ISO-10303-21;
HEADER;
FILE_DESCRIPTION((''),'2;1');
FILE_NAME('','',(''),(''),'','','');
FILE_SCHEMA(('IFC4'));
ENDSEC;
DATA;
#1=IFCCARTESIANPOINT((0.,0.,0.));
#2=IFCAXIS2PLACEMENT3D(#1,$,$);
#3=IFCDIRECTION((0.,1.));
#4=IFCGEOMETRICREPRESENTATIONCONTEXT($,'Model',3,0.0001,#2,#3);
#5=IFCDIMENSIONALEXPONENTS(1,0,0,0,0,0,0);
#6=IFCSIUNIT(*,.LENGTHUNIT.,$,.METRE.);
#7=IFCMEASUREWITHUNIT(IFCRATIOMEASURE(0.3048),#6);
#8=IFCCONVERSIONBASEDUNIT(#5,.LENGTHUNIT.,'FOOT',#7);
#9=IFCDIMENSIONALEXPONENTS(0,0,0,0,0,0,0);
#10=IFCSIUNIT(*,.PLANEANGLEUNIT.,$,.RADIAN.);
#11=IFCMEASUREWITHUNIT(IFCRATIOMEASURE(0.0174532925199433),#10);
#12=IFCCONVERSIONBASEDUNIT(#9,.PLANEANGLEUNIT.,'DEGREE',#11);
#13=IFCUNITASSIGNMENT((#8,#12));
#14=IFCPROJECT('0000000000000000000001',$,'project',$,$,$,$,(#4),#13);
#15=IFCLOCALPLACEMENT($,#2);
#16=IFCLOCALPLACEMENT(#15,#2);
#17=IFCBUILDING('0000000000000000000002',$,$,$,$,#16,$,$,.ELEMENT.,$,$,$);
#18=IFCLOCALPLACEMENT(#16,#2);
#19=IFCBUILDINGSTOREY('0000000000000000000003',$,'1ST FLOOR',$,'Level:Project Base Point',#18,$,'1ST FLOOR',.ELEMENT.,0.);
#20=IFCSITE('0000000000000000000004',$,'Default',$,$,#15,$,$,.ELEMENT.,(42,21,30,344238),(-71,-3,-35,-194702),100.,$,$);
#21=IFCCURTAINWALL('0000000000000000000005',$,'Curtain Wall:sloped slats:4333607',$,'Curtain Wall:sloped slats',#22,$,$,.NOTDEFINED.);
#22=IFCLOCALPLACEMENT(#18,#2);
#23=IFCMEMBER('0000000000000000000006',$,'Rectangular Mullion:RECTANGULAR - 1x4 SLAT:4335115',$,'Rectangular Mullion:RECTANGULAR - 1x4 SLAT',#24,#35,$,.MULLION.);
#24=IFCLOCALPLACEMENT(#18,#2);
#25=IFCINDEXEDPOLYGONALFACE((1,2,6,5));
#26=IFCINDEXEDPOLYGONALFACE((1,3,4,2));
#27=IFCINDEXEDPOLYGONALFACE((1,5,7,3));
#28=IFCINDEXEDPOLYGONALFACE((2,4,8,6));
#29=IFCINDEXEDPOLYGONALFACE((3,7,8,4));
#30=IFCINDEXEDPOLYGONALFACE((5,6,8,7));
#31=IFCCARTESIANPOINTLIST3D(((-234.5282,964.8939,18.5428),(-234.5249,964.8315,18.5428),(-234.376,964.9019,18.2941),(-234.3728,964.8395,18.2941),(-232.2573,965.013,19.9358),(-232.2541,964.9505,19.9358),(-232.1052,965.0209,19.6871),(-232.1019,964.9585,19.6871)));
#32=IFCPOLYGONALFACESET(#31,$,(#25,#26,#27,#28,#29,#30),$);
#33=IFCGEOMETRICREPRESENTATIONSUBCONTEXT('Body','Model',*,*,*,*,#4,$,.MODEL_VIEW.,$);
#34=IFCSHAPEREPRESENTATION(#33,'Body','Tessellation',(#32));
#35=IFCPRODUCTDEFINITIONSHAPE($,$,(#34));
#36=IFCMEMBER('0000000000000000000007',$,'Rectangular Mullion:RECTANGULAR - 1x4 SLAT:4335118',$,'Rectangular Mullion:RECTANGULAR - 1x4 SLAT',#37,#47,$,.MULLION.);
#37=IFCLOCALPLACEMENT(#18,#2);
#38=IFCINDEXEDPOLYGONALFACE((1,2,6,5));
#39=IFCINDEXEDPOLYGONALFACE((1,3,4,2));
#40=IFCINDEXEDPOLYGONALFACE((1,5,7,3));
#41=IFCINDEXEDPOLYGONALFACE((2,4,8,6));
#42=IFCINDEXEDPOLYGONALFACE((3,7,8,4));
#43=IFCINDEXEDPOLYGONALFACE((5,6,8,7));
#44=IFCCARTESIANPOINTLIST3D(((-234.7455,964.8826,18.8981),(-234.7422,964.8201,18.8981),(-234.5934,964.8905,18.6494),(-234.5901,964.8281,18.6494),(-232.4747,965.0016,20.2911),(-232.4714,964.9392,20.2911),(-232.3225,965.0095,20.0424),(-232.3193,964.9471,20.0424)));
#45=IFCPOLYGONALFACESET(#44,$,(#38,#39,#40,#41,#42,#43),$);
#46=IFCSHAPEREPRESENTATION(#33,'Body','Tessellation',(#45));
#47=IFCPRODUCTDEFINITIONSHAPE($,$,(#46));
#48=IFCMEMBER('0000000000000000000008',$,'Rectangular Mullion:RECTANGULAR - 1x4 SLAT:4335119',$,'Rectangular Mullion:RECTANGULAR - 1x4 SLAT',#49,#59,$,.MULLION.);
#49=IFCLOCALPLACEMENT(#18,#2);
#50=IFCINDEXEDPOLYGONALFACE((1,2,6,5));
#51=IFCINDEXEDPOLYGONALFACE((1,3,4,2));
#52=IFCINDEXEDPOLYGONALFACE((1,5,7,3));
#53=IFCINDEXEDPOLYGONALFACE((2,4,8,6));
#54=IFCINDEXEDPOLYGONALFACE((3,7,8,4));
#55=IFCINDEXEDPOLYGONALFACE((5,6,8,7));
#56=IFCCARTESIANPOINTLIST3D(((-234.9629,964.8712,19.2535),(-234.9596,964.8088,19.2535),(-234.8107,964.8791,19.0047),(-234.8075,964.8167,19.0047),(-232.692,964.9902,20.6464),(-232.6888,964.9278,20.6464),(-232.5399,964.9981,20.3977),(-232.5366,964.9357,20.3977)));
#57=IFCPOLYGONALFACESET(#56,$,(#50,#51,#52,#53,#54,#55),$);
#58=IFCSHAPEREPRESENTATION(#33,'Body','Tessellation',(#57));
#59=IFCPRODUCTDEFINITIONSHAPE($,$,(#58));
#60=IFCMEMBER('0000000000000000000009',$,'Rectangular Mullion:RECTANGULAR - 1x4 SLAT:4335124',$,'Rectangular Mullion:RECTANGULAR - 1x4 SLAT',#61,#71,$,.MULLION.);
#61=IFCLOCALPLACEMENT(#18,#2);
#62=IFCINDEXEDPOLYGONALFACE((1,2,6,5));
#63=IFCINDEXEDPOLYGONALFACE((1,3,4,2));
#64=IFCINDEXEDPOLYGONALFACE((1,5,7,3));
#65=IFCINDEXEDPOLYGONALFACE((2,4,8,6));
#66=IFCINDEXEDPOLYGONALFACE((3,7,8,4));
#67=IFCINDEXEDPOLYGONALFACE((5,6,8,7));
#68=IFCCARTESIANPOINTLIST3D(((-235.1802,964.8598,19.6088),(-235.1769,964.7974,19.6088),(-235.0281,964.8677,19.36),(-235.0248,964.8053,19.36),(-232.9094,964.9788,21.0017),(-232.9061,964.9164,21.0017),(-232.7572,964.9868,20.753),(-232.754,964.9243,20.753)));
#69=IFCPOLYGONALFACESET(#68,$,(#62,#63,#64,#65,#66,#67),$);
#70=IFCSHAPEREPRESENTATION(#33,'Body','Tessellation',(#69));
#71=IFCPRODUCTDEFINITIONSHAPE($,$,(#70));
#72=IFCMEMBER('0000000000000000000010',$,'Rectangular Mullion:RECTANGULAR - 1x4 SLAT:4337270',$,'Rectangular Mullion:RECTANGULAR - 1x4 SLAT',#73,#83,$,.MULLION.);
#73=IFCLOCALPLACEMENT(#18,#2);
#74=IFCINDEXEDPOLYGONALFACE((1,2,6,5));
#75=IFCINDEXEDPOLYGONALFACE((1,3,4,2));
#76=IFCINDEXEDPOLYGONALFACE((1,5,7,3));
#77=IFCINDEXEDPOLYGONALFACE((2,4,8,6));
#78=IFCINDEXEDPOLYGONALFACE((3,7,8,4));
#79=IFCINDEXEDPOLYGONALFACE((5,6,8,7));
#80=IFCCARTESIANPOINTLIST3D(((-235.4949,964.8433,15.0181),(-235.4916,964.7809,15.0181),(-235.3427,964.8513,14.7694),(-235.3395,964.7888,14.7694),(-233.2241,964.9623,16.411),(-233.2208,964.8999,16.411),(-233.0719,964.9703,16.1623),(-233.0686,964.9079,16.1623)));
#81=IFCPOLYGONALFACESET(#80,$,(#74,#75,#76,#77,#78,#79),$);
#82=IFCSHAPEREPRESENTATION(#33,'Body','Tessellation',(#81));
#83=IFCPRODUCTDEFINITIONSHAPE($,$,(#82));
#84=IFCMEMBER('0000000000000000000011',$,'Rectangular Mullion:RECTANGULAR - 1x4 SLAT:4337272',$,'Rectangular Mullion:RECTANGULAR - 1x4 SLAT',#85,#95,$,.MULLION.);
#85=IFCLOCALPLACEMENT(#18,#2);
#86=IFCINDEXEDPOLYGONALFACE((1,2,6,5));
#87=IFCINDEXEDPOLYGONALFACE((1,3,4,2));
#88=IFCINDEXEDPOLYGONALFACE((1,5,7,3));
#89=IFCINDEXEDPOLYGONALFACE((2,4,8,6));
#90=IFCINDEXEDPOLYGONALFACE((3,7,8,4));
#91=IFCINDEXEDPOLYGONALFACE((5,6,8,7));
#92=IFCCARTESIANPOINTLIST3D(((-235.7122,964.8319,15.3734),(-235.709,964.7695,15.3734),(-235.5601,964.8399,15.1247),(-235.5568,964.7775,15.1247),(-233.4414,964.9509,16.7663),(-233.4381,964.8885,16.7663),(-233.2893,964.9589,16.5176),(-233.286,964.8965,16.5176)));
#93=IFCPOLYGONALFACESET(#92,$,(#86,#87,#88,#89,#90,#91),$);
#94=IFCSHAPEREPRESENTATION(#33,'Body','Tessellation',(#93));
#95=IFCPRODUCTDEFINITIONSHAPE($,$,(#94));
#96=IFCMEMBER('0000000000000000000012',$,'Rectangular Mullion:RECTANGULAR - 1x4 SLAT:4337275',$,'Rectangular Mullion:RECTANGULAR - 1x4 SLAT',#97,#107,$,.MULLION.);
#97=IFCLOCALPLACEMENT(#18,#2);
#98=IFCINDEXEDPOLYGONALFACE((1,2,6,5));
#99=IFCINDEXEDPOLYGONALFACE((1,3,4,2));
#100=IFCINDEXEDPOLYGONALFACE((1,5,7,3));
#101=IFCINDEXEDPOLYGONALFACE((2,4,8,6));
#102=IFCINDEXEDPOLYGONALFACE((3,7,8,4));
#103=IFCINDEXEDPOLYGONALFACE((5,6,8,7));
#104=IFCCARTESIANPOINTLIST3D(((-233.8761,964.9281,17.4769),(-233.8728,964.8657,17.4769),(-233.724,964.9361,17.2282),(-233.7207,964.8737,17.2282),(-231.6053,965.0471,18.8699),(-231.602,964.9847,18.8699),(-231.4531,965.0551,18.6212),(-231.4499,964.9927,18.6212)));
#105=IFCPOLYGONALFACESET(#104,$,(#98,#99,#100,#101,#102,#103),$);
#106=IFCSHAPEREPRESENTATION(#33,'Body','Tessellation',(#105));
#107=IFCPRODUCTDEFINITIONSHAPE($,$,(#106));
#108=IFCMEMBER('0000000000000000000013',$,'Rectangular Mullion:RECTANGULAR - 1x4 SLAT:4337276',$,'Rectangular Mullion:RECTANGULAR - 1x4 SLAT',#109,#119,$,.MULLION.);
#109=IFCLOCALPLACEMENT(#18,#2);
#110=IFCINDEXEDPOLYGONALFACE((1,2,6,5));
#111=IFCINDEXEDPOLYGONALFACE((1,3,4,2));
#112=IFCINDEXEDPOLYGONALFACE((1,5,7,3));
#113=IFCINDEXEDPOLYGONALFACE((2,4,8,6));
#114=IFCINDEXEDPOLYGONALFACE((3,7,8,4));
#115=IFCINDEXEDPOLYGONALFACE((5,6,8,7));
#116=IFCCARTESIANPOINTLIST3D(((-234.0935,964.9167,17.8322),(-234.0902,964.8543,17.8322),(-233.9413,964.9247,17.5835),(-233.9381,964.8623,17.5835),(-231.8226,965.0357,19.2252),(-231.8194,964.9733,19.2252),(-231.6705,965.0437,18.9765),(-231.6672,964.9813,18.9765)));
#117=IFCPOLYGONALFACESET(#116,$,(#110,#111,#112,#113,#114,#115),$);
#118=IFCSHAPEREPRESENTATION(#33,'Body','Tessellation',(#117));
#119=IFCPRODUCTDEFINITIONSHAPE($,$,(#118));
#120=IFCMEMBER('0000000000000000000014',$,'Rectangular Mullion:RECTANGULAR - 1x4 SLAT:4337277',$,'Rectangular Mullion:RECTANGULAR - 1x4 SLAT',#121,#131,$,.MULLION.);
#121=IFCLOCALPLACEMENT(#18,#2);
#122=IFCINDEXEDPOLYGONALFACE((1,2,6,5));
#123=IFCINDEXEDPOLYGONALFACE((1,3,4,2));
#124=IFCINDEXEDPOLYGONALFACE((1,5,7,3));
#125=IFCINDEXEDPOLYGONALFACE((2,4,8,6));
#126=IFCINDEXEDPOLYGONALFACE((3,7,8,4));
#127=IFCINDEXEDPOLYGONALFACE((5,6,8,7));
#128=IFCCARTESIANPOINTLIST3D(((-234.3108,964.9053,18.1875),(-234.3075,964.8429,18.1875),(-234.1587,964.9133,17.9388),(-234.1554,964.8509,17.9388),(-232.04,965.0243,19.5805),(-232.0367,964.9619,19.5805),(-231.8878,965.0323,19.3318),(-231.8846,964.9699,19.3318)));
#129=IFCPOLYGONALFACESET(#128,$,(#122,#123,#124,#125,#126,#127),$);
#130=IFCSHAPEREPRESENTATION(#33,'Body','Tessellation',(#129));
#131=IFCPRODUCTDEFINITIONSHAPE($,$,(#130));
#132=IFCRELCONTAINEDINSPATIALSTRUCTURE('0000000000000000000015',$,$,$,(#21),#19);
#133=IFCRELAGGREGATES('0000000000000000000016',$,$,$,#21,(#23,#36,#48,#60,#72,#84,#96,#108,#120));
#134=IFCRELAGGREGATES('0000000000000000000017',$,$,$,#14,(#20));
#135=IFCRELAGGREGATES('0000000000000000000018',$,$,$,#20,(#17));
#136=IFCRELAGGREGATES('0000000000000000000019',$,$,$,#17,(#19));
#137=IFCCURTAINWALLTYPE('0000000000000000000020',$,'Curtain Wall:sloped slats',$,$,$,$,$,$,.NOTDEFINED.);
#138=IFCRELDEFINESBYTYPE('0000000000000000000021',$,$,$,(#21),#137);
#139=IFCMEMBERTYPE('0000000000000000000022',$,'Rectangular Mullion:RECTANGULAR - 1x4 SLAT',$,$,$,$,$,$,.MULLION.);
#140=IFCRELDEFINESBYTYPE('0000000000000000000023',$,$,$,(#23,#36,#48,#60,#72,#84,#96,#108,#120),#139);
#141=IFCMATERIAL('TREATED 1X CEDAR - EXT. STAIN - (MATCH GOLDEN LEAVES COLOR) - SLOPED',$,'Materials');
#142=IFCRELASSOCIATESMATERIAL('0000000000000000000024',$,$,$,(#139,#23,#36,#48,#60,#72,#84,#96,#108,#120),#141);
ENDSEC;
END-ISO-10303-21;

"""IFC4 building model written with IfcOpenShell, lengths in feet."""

from ifc_helpers import new_model, entity, si_unit, converted_unit, direction, frame, frame_2d, origin, place, context, subcontext, project, spatial, rectangle, extrude, source, transform, mapped, material, material_profile, profile_set, profile_usage, type_object, type_shapes, element, aggregate, save


model = new_model("IFC4")

# Units and contexts
model_context = context("Model", 3, precision=0.0001, world=origin(), true_north=direction((0.0, 1.0)))
body_context = subcontext(model_context, "Body", "Model", "MODEL_VIEW")
ifc_project = project(units=[converted_unit("LENGTHUNIT", "FOOT", entity("IfcRatioMeasure", 0.3048), si_unit("LENGTHUNIT", "METRE"), dimensions=[1, 0, 0, 0, 0, 0, 0]), converted_unit("PLANEANGLEUNIT", "DEGREE", entity("IfcRatioMeasure", 0.0174532925199433), si_unit("PLANEANGLEUNIT", "RADIAN"), dimensions=[0, 0, 0, 0, 0, 0, 0])], contexts=[model_context])

# Site, building, storey
site_placement = place(None, origin())
site = spatial("IfcSite", under=ifc_project, at=site_placement, Name="Default", CompositionType="ELEMENT", RefLatitude=(42, 21, 30, 344238), RefLongitude=(-71, -3, -35, -194702), RefElevation=100.0)
building_placement = place(site_placement, origin())
building = spatial("IfcBuilding", under=site, at=building_placement, CompositionType="ELEMENT")
storey_placement = place(building_placement, origin())
storey = spatial("IfcBuildingStorey", under=building, at=storey_placement, Name="1ST FLOOR", ObjectType="Level:Project Base Point", LongName="1ST FLOOR", CompositionType="ELEMENT", Elevation=0.0)

# Curtain wall, members
curtain_wall_type_1 = type_object("IfcCurtainWallType", Name="Curtain Wall:sloped slats", PredefinedType="NOTDEFINED")
curtain_wall_1_placement = place(storey_placement, origin())
curtain_wall_1 = element("IfcCurtainWall", 1, at=curtain_wall_1_placement, inside=storey, type_object=curtain_wall_type_1, Name="Curtain Wall:sloped slats:4333607", ObjectType="Curtain Wall:sloped slats", PredefinedType="NOTDEFINED")
ifc_material_1 = material(Name="TREATED 1X CEDAR - EXT. STAIN - (MATCH GOLDEN LEAVES COLOR) - SLOPED", Category="Materials")
ifc_material_profile_1 = material_profile(ifc_material_1, rectangle(XDim=0.0625, YDim=0.2917, at=frame_2d((0.0, 0.0), x_axis=(1.0, 0.0))), Name="RECTANGULAR - 1x4 SLAT")
ifc_profile_set_1 = profile_set([ifc_material_profile_1], Name="RECTANGULAR - 1x4 SLAT")
member_type_1 = type_object("IfcMemberType", Name="Rectangular Mullion:RECTANGULAR - 1x4 SLAT", PredefinedType="MULLION", material=ifc_profile_set_1)
shared_shape_1 = source(origin(), body_context, "Body", "SweptSolid", [
    extrude(rectangle(XDim=0.0625, YDim=0.2917, at=frame_2d((0.0, 0.0), x_axis=(1.0, 0.0))), frame((0.0, 0.0, -2.6667), z_axis=(0.0, 0.0, 1.0), x_axis=(0.0, -1.0, 0.0)), (0.0, 0.0, 1.0), 2.6667),
])
type_shapes(member_type_1, [shared_shape_1])
ifc_profile_usage_1 = profile_usage(ifc_profile_set_1)
member_1_placement = place(storey_placement, frame((-234.4505, 964.8667, 18.4185), z_axis=(-0.851559, -0.044628, -0.522356), x_axis=(-0.52164, -0.027338, 0.852727)))
member_1 = element("IfcMember", 2, at=member_1_placement, type_object=member_type_1, material=ifc_profile_usage_1, Name="Rectangular Mullion:RECTANGULAR - 1x4 SLAT:4335115", ObjectType="Rectangular Mullion:RECTANGULAR - 1x4 SLAT", PredefinedType="MULLION", context=body_context, shape_type="MappedRepresentation", body=[
    mapped(shared_shape_1, transform((0.0, 0.0, 0.0), scale=1.0)),
])
ifc_profile_usage_2 = profile_usage(ifc_profile_set_1)
member_2_placement = place(storey_placement, frame((-234.6678, 964.8553, 18.7738), z_axis=(-0.851559, -0.044628, -0.522356), x_axis=(-0.52164, -0.027338, 0.852727)))
member_2 = element("IfcMember", 3, at=member_2_placement, type_object=member_type_1, material=ifc_profile_usage_2, Name="Rectangular Mullion:RECTANGULAR - 1x4 SLAT:4335118", ObjectType="Rectangular Mullion:RECTANGULAR - 1x4 SLAT", PredefinedType="MULLION", context=body_context, shape_type="MappedRepresentation", body=[
    mapped(shared_shape_1, transform((0.0, 0.0, 0.0), scale=1.0)),
])
ifc_profile_usage_3 = profile_usage(ifc_profile_set_1)
member_3_placement = place(storey_placement, frame((-234.8852, 964.8439, 19.1291), z_axis=(-0.851559, -0.044628, -0.522356), x_axis=(-0.52164, -0.027338, 0.852727)))
member_3 = element("IfcMember", 4, at=member_3_placement, type_object=member_type_1, material=ifc_profile_usage_3, Name="Rectangular Mullion:RECTANGULAR - 1x4 SLAT:4335119", ObjectType="Rectangular Mullion:RECTANGULAR - 1x4 SLAT", PredefinedType="MULLION", context=body_context, shape_type="MappedRepresentation", body=[
    mapped(shared_shape_1, transform((0.0, 0.0, 0.0), scale=1.0)),
])
ifc_profile_usage_4 = profile_usage(ifc_profile_set_1)
member_4_placement = place(storey_placement, frame((-235.1025, 964.8326, 19.4844), z_axis=(-0.851559, -0.044628, -0.522356), x_axis=(-0.52164, -0.027338, 0.852727)))
member_4 = element("IfcMember", 5, at=member_4_placement, type_object=member_type_1, material=ifc_profile_usage_4, Name="Rectangular Mullion:RECTANGULAR - 1x4 SLAT:4335124", ObjectType="Rectangular Mullion:RECTANGULAR - 1x4 SLAT", PredefinedType="MULLION", context=body_context, shape_type="MappedRepresentation", body=[
    mapped(shared_shape_1, transform((0.0, 0.0, 0.0), scale=1.0)),
])
ifc_profile_usage_5 = profile_usage(ifc_profile_set_1)
member_5_placement = place(storey_placement, frame((-235.4172, 964.8161, 14.8937), z_axis=(-0.851559, -0.044628, -0.522356), x_axis=(-0.52164, -0.027338, 0.852727)))
member_5 = element("IfcMember", 6, at=member_5_placement, type_object=member_type_1, material=ifc_profile_usage_5, Name="Rectangular Mullion:RECTANGULAR - 1x4 SLAT:4337270", ObjectType="Rectangular Mullion:RECTANGULAR - 1x4 SLAT", PredefinedType="MULLION", context=body_context, shape_type="MappedRepresentation", body=[
    mapped(shared_shape_1, transform((0.0, 0.0, 0.0), scale=1.0)),
])
ifc_profile_usage_6 = profile_usage(ifc_profile_set_1)
member_6_placement = place(storey_placement, frame((-235.6345, 964.8047, 15.249), z_axis=(-0.851559, -0.044628, -0.522356), x_axis=(-0.52164, -0.027338, 0.852727)))
member_6 = element("IfcMember", 7, at=member_6_placement, type_object=member_type_1, material=ifc_profile_usage_6, Name="Rectangular Mullion:RECTANGULAR - 1x4 SLAT:4337272", ObjectType="Rectangular Mullion:RECTANGULAR - 1x4 SLAT", PredefinedType="MULLION", context=body_context, shape_type="MappedRepresentation", body=[
    mapped(shared_shape_1, transform((0.0, 0.0, 0.0), scale=1.0)),
])
ifc_profile_usage_7 = profile_usage(ifc_profile_set_1)
member_7_placement = place(storey_placement, frame((-233.7984, 964.9009, 17.3526), z_axis=(-0.851559, -0.044628, -0.522356), x_axis=(-0.52164, -0.027338, 0.852727)))
member_7 = element("IfcMember", 8, at=member_7_placement, type_object=member_type_1, material=ifc_profile_usage_7, Name="Rectangular Mullion:RECTANGULAR - 1x4 SLAT:4337275", ObjectType="Rectangular Mullion:RECTANGULAR - 1x4 SLAT", PredefinedType="MULLION", context=body_context, shape_type="MappedRepresentation", body=[
    mapped(shared_shape_1, transform((0.0, 0.0, 0.0), scale=1.0)),
])
ifc_profile_usage_8 = profile_usage(ifc_profile_set_1)
member_8_placement = place(storey_placement, frame((-234.0158, 964.8895, 17.7079), z_axis=(-0.851559, -0.044628, -0.522356), x_axis=(-0.52164, -0.027338, 0.852727)))
member_8 = element("IfcMember", 9, at=member_8_placement, type_object=member_type_1, material=ifc_profile_usage_8, Name="Rectangular Mullion:RECTANGULAR - 1x4 SLAT:4337276", ObjectType="Rectangular Mullion:RECTANGULAR - 1x4 SLAT", PredefinedType="MULLION", context=body_context, shape_type="MappedRepresentation", body=[
    mapped(shared_shape_1, transform((0.0, 0.0, 0.0), scale=1.0)),
])
ifc_profile_usage_9 = profile_usage(ifc_profile_set_1)
member_9_placement = place(storey_placement, frame((-234.2331, 964.8781, 18.0632), z_axis=(-0.851559, -0.044628, -0.522356), x_axis=(-0.52164, -0.027338, 0.852727)))
member_9 = element("IfcMember", 10, at=member_9_placement, type_object=member_type_1, material=ifc_profile_usage_9, Name="Rectangular Mullion:RECTANGULAR - 1x4 SLAT:4337277", ObjectType="Rectangular Mullion:RECTANGULAR - 1x4 SLAT", PredefinedType="MULLION", context=body_context, shape_type="MappedRepresentation", body=[
    mapped(shared_shape_1, transform((0.0, 0.0, 0.0), scale=1.0)),
])
aggregate(curtain_wall_1, [member_1, member_2, member_3, member_4, member_5, member_6, member_7, member_8, member_9])

save(model, "model.ifc")
